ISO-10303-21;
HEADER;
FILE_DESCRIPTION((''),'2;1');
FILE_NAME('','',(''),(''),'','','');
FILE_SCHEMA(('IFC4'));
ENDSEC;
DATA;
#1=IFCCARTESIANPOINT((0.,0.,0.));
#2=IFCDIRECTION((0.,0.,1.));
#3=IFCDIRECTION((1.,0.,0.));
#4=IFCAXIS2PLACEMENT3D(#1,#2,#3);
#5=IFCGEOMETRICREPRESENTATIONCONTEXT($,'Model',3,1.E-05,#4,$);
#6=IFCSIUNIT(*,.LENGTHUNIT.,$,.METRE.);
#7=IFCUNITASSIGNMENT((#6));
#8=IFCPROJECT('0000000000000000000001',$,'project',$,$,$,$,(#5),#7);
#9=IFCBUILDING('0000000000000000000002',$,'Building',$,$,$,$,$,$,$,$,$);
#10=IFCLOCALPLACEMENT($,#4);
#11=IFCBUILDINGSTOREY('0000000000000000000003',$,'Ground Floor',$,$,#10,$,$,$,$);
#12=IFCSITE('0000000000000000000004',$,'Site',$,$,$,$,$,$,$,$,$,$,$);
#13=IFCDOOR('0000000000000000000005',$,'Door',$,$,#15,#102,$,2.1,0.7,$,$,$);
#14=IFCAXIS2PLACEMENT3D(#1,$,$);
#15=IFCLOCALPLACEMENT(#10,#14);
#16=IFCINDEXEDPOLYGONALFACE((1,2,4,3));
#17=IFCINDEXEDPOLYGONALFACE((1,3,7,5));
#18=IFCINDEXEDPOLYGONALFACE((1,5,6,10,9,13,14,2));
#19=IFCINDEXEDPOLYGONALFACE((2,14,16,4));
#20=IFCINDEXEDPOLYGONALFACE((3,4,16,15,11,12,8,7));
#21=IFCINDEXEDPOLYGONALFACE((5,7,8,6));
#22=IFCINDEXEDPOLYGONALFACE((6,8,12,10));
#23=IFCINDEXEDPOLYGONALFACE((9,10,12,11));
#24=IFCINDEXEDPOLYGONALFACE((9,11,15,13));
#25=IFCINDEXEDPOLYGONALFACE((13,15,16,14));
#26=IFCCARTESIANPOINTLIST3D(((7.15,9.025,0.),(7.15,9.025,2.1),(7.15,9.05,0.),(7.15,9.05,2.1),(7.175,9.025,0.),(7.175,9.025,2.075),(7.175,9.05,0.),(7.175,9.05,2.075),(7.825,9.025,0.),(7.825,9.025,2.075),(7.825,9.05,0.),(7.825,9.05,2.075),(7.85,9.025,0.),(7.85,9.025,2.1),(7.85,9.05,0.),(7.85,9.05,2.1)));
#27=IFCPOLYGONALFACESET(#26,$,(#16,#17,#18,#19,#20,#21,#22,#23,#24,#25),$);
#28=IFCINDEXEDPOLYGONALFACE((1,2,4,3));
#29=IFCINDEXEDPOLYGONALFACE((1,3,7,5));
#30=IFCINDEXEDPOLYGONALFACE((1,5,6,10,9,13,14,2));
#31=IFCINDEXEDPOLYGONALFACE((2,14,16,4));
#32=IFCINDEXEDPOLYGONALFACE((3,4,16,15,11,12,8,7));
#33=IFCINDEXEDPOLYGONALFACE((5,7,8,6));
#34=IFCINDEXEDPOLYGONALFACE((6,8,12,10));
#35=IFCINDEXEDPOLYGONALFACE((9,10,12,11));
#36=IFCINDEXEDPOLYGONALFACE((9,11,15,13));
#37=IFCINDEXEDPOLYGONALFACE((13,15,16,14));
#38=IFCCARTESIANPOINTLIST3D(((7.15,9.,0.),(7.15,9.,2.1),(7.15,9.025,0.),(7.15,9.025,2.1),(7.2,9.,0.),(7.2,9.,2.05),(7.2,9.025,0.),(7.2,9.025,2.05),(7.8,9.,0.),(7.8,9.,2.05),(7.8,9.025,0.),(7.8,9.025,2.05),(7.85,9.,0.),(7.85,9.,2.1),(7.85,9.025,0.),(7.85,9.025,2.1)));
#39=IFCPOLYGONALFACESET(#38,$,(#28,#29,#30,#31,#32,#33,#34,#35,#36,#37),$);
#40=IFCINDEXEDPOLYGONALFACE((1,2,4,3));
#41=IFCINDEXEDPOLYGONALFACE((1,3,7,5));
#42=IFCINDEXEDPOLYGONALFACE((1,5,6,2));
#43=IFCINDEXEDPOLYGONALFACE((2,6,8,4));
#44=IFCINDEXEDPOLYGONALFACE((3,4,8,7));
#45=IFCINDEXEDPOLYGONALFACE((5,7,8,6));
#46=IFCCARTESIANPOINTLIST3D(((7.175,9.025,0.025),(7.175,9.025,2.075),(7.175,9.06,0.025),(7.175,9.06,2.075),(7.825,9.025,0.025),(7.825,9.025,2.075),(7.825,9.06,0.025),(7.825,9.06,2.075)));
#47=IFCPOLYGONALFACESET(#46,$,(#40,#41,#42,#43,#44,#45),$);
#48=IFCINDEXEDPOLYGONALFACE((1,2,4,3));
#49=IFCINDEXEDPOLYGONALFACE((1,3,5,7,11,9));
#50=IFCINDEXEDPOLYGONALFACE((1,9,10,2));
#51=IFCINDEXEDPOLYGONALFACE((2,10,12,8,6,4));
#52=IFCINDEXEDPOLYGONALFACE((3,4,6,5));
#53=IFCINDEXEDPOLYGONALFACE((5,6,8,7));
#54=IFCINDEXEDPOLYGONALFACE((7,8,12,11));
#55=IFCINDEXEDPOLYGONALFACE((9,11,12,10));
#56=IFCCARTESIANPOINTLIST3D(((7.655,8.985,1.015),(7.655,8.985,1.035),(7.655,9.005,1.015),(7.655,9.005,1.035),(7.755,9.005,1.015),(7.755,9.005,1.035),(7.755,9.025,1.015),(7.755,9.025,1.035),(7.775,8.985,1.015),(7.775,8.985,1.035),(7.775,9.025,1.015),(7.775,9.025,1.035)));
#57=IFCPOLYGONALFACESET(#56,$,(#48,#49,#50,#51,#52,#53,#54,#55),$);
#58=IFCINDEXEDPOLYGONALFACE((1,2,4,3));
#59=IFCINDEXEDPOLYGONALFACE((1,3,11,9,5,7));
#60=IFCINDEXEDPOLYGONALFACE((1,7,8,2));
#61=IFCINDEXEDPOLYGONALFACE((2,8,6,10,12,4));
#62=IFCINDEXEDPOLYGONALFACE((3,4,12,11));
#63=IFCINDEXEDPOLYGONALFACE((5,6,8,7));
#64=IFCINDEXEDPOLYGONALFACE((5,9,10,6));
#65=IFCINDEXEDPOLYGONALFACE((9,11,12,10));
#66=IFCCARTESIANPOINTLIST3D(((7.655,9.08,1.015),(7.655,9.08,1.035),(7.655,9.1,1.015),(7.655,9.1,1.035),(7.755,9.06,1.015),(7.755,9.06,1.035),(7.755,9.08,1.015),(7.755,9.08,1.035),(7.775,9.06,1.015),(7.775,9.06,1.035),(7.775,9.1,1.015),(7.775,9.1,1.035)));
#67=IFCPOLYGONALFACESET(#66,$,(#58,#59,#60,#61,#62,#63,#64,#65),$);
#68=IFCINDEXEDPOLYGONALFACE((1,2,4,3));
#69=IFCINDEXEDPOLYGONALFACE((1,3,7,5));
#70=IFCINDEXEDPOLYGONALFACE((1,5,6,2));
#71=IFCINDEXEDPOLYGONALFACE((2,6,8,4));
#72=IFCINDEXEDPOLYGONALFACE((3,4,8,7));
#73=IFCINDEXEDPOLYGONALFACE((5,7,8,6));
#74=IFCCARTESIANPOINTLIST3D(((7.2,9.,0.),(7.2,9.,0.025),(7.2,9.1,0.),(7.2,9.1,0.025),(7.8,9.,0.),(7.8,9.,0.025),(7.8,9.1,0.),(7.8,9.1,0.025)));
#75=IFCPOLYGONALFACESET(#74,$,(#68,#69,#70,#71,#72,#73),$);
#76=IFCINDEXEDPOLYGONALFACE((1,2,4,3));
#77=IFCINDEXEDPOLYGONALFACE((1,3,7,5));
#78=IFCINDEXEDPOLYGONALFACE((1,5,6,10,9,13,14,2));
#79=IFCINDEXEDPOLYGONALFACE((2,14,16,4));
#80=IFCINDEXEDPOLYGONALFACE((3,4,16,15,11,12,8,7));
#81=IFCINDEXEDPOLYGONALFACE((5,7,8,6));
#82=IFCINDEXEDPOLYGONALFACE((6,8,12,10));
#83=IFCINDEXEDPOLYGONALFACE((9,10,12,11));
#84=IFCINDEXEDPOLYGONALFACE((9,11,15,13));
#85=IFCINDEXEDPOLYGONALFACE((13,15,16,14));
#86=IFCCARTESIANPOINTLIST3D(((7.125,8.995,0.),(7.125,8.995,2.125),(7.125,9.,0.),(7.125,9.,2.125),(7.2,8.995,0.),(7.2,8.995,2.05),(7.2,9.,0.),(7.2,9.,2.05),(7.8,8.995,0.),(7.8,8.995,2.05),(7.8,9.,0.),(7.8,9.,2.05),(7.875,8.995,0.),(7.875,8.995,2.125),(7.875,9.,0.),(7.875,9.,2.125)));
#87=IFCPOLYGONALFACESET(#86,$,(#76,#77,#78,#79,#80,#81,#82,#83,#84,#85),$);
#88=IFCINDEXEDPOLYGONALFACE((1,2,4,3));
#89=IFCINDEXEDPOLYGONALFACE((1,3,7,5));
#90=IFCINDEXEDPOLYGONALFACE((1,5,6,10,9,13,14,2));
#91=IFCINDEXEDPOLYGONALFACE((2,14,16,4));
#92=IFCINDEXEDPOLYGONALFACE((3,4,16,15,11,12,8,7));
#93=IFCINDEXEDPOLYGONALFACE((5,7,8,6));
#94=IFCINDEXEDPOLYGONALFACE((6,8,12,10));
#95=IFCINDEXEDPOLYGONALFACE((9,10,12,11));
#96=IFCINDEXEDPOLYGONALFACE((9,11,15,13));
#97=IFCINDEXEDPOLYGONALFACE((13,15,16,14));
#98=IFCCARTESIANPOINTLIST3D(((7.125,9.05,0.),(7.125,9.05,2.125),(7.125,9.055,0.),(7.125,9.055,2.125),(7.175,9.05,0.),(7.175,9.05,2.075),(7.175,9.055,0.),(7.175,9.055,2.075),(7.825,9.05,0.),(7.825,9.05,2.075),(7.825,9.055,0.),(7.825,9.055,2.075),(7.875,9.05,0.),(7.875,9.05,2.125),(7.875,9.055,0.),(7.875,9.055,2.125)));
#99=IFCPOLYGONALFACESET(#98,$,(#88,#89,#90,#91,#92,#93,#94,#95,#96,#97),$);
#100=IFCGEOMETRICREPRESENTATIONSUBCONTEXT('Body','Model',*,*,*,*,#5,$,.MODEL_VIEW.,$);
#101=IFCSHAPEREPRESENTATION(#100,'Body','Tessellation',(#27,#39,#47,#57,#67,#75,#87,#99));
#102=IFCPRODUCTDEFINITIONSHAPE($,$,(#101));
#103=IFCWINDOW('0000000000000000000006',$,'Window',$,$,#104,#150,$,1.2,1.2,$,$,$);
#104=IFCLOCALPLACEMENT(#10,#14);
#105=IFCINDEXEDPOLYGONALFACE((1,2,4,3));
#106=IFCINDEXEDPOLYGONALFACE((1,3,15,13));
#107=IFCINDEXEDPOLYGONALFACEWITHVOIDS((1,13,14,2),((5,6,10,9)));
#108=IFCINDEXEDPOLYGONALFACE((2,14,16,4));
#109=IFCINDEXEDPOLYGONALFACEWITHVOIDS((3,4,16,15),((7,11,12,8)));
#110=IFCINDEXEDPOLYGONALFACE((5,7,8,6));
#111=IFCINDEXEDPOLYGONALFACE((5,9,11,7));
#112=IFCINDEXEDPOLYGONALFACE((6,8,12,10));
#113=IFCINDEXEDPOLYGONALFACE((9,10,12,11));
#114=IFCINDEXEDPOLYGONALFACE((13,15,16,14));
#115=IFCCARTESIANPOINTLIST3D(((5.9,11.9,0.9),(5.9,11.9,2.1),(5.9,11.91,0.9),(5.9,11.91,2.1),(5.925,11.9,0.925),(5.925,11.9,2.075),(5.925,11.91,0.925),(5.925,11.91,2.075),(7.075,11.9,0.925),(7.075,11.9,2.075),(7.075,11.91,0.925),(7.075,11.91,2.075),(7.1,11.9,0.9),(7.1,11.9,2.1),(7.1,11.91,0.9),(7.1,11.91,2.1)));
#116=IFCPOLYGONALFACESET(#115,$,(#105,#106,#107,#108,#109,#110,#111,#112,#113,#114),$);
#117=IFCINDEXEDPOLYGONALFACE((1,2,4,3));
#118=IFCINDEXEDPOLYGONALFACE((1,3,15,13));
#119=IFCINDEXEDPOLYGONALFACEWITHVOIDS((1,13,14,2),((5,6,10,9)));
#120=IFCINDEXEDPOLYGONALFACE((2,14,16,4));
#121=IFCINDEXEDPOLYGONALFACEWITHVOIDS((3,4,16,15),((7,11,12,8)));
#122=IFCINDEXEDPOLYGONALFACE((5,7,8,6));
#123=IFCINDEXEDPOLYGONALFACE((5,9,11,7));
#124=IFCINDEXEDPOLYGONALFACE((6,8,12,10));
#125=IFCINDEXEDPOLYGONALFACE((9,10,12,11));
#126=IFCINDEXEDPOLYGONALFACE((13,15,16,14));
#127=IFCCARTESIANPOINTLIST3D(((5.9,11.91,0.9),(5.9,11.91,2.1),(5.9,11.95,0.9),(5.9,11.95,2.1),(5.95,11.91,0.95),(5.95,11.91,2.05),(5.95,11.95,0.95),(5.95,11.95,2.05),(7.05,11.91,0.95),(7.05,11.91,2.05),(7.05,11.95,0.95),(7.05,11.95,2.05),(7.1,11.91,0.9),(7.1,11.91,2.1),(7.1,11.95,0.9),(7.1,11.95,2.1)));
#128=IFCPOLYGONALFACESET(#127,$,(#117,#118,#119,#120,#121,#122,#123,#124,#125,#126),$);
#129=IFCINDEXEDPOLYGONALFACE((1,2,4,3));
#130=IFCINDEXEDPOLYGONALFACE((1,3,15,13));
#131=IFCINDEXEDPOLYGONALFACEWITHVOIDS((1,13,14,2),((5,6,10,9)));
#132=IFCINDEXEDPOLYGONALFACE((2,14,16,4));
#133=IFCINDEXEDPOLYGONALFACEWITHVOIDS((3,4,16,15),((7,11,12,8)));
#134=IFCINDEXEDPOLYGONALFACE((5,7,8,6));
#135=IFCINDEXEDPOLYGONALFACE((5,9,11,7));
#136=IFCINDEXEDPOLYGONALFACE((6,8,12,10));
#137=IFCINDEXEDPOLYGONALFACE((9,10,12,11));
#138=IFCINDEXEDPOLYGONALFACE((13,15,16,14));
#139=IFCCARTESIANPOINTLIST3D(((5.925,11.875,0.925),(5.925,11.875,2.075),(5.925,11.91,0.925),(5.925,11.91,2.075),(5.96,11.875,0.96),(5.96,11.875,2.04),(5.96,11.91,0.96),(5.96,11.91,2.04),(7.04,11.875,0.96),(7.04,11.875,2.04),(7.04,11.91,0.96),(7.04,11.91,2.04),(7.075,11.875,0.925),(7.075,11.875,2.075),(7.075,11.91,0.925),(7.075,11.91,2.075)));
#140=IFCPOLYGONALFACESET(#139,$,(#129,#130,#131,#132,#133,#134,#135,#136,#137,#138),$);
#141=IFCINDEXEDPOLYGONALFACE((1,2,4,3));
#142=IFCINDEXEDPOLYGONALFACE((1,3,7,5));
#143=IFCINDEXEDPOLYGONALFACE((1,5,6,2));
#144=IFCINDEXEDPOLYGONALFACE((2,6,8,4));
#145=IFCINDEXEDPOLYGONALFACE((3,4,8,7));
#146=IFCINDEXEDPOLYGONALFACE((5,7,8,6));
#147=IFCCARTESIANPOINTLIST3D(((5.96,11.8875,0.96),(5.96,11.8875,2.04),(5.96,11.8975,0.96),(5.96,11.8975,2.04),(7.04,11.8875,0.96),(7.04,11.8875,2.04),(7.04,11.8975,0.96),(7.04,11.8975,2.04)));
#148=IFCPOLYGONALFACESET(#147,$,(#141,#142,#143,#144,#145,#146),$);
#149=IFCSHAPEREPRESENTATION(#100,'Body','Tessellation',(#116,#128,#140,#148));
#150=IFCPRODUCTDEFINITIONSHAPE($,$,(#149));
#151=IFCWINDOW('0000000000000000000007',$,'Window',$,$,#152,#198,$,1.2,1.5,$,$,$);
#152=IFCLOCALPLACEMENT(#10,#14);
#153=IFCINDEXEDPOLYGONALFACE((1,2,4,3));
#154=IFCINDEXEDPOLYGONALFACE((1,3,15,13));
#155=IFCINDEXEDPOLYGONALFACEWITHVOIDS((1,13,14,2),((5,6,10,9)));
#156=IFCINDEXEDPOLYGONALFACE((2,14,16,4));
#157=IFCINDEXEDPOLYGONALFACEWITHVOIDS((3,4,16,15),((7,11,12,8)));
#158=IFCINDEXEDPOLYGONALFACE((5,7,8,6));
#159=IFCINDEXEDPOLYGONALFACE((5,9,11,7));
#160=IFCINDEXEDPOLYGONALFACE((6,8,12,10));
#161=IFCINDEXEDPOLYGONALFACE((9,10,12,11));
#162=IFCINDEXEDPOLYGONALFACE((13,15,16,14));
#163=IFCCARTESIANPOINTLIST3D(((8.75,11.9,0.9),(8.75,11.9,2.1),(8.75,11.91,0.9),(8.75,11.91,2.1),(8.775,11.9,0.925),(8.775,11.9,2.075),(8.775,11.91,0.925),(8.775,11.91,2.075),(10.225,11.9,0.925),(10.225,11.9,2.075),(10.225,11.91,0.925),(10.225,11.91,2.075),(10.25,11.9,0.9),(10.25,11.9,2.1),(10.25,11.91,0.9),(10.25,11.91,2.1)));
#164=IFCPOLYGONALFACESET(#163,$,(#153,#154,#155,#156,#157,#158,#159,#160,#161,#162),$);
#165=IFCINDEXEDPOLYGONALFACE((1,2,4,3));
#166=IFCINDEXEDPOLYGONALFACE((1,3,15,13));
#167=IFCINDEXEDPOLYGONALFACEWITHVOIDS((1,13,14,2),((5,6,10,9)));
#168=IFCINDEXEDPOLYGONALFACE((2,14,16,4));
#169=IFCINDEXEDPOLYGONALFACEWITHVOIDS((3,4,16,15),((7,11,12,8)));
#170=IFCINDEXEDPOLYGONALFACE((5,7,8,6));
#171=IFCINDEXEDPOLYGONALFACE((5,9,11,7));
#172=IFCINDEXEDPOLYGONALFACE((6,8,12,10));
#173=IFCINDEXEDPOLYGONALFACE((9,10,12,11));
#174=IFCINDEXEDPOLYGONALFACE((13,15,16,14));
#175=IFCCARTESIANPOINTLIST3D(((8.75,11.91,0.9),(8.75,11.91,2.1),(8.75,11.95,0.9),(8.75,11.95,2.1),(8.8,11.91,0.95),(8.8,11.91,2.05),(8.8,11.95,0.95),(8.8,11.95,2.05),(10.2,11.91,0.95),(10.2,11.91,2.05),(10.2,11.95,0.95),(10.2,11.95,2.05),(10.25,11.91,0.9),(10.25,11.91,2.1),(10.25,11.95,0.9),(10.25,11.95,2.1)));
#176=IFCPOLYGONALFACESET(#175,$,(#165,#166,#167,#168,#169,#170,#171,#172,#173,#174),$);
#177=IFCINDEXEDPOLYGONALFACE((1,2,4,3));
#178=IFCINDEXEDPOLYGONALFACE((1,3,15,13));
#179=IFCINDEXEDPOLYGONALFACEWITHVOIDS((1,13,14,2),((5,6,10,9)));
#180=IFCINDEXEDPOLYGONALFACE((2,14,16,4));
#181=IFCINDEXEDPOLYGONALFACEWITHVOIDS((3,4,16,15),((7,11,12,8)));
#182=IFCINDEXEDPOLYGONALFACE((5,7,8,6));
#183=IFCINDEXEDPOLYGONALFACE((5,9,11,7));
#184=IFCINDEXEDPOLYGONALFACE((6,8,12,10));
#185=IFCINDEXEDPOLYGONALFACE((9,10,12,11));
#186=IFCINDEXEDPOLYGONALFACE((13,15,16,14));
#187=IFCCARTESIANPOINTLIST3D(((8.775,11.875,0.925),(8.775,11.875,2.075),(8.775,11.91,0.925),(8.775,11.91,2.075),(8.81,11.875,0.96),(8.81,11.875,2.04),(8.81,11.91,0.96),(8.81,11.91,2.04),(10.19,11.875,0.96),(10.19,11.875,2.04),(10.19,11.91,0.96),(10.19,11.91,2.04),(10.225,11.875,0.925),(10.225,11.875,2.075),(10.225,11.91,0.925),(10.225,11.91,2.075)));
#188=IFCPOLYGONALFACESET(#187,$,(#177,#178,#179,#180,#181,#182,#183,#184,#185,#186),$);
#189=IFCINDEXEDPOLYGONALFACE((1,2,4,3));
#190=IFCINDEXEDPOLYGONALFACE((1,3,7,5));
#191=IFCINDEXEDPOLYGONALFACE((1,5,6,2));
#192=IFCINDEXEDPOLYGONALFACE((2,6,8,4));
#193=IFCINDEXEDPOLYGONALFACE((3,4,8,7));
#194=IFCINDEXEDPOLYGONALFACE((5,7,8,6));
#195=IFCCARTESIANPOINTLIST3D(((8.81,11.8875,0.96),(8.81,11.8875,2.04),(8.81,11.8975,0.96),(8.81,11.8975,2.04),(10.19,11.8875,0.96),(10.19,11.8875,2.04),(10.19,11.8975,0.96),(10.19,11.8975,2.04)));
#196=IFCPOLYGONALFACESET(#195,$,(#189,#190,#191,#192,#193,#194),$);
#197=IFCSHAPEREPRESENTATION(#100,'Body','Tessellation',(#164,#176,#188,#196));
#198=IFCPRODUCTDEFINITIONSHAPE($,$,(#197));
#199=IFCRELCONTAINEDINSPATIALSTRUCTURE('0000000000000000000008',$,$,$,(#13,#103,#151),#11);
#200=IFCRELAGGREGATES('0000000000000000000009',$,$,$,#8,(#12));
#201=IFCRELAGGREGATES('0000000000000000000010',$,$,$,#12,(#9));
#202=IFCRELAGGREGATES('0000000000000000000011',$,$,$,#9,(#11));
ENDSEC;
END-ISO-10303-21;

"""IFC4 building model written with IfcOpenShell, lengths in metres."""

from ifc_helpers import new_model, si_unit, frame, origin_with_axes, place, context, subcontext, project, spatial, line, indexed_curve, outline, extrude, element, save


model = new_model("IFC4")

# Units and contexts
model_context = context("Model", 3, precision=1e-05, world=origin_with_axes())
body_context = subcontext(model_context, "Body", "Model", "MODEL_VIEW")
ifc_project = project(units=[si_unit("LENGTHUNIT", "METRE")], contexts=[model_context])

# Site, building, storey
site = spatial("IfcSite", under=ifc_project, Name="Site")
building = spatial("IfcBuilding", under=site, Name="Building")
storey_placement = place(None, origin_with_axes())
storey = spatial("IfcBuildingStorey", under=building, at=storey_placement, Name="Ground Floor")

# Door
door_1_placement = place(storey_placement, frame((7.15, 9.0, 0.0), z_axis=(0.0, 0.0, 1.0), x_axis=(1.0, 0.0, 0.0)))
element("IfcDoor", 1, at=door_1_placement, inside=storey, Name="Door", OverallHeight=2.1, OverallWidth=0.7, context=body_context, shape_type="SweptSolid", body=[
    extrude(outline(indexed_curve([(0.0, 0.0), (0.0, 2.1), (0.7, 2.1), (0.7, 0.0), (0.675, 0.0), (0.675, 2.075), (0.025, 2.075), (0.025, 0.0)], segments=[line(1, 2, 3, 4, 5, 6, 7, 8, 1)])), frame((0.0, 0.025, 0.0), z_axis=(0.0, -1.0, 0.0), x_axis=(1.0, 0.0, 0.0)), (0.0, 0.0, -1.0), 0.025),
    extrude(outline(indexed_curve([(0.0, 0.0), (0.0, 2.1), (0.7, 2.1), (0.7, 0.0), (0.65, 0.0), (0.65, 2.05), (0.05, 2.05), (0.05, 0.0)], segments=[line(1, 2, 3, 4, 5, 6, 7, 8, 1)])), frame((0.0, 0.0, 0.0), z_axis=(0.0, -1.0, 0.0), x_axis=(1.0, 0.0, 0.0)), (0.0, 0.0, -1.0), 0.025),
    extrude(outline(indexed_curve([(0.0, 0.0), (0.65, 0.0), (0.65, 0.035), (0.0, 0.035)], segments=[line(1, 2, 3, 4, 1)])), frame((0.025, 0.025, 0.025), z_axis=(0.0, 0.0, 1.0), x_axis=(1.0, 0.0, 0.0)), (0.0, 0.0, 1.0), 2.05),
    extrude(outline(indexed_curve([(0.0, 0.0), (0.0, -0.04), (-0.12, -0.04), (-0.12, -0.02), (-0.02, -0.02), (-0.02, 0.0)], segments=[line(1, 2, 3, 4, 5, 6, 1)])), frame((0.625, 0.025, 1.015), z_axis=(0.0, 0.0, 1.0), x_axis=(1.0, 0.0, 0.0)), (0.0, 0.0, 1.0), 0.02),
    extrude(outline(indexed_curve([(0.0, 0.0), (0.0, 0.04), (-0.12, 0.04), (-0.12, 0.02), (-0.02, 0.02), (-0.02, 0.0)], segments=[line(1, 2, 3, 4, 5, 6, 1)])), frame((0.625, 0.06, 1.015), z_axis=(0.0, 0.0, 1.0), x_axis=(1.0, 0.0, 0.0)), (0.0, 0.0, 1.0), 0.02),
    extrude(outline(indexed_curve([(0.0, 0.0), (0.6, 0.0), (0.6, 0.1), (0.0, 0.1)], segments=[line(1, 2, 3, 4, 1)])), frame((0.05, 0.0, 0.0), z_axis=(0.0, 0.0, 1.0), x_axis=(1.0, 0.0, 0.0)), (0.0, 0.0, 1.0), 0.025),
    extrude(outline(indexed_curve([(0.0, 0.0), (0.0, 2.125), (0.75, 2.125), (0.75, 0.0), (0.675, 0.0), (0.675, 2.05), (0.075, 2.05), (0.075, 0.0)], segments=[line(1, 2, 3, 4, 5, 6, 7, 8, 1)])), frame((-0.025, -0.005, 0.0), z_axis=(0.0, -1.0, 0.0), x_axis=(1.0, 0.0, 0.0)), (0.0, 0.0, -1.0), 0.005),
    extrude(outline(indexed_curve([(0.0, 0.0), (0.0, 2.125), (0.75, 2.125), (0.75, 0.0), (0.7, 0.0), (0.7, 2.075), (0.05, 2.075), (0.05, 0.0)], segments=[line(1, 2, 3, 4, 5, 6, 7, 8, 1)])), frame((-0.025, 0.05, 0.0), z_axis=(0.0, -1.0, 0.0), x_axis=(1.0, 0.0, 0.0)), (0.0, 0.0, -1.0), 0.005),
])

# Windows
window_placement = place(storey_placement, frame((7.1, 12.0, 0.9), z_axis=(0.0, 0.0, 1.0), x_axis=(-1.0, 0.0, 0.0)))
element("IfcWindow", 2, at=window_placement, inside=storey, Name="Window", OverallHeight=1.2, OverallWidth=1.2, context=body_context, shape_type="SweptSolid", body=[
    extrude(outline(indexed_curve([(0.0, 0.0), (1.2, 0.0), (1.2, 1.2), (0.0, 1.2)], segments=[line(1, 2, 3, 4, 1)]), holes=[indexed_curve([(0.025, 0.025), (1.175, 0.025), (1.175, 1.175), (0.025, 1.175)], segments=[line(1, 2, 3, 4, 1)])]), frame((0.0, 0.09, 0.0), z_axis=(0.0, -1.0, 0.0), x_axis=(1.0, 0.0, 0.0)), (0.0, 0.0, -1.0), 0.01),
    extrude(outline(indexed_curve([(0.0, 0.0), (1.2, 0.0), (1.2, 1.2), (0.0, 1.2)], segments=[line(1, 2, 3, 4, 1)]), holes=[indexed_curve([(0.05, 0.05), (1.15, 0.05), (1.15, 1.15), (0.05, 1.15)], segments=[line(1, 2, 3, 4, 1)])]), frame((0.0, 0.05, 0.0), z_axis=(0.0, -1.0, 0.0), x_axis=(1.0, 0.0, 0.0)), (0.0, 0.0, -1.0), 0.04),
    extrude(outline(indexed_curve([(0.0, 0.0), (1.15, 0.0), (1.15, 1.15), (0.0, 1.15)], segments=[line(1, 2, 3, 4, 1)]), holes=[indexed_curve([(0.035, 0.035), (1.115, 0.035), (1.115, 1.115), (0.035, 1.115)], segments=[line(1, 2, 3, 4, 1)])]), frame((0.025, 0.09, 0.025), z_axis=(0.0, -1.0, 0.0), x_axis=(1.0, 0.0, 0.0)), (0.0, 0.0, -1.0), 0.035),
    extrude(outline(indexed_curve([(0.035, 0.035), (1.115, 0.035), (1.115, 1.115), (0.035, 1.115)], segments=[line(1, 2, 3, 4, 1)])), frame((0.025, 0.1025, 0.025), z_axis=(0.0, -1.0, 0.0), x_axis=(1.0, 0.0, 0.0)), (0.0, 0.0, -1.0), 0.01),
])
for number, where, z_axis, x_axis, name in (
    (3, (10.25, 12.0, 0.9), (0.0, 0.0, 1.0), (-1.0, 0.0, 0.0), "Window"),
):
    element("IfcWindow", number, at=place(storey_placement, frame(where, z_axis=z_axis, x_axis=x_axis)), inside=storey, Name=name, OverallHeight=1.2, OverallWidth=1.5, context=body_context, shape_type="SweptSolid", body=[
        extrude(outline(indexed_curve([(0.0, 0.0), (1.5, 0.0), (1.5, 1.2), (0.0, 1.2)], segments=[line(1, 2, 3, 4, 1)]), holes=[indexed_curve([(0.025, 0.025), (1.475, 0.025), (1.475, 1.175), (0.025, 1.175)], segments=[line(1, 2, 3, 4, 1)])]), frame((0.0, 0.09, 0.0), z_axis=(0.0, -1.0, 0.0), x_axis=(1.0, 0.0, 0.0)), (0.0, 0.0, -1.0), 0.01),
        extrude(outline(indexed_curve([(0.0, 0.0), (1.5, 0.0), (1.5, 1.2), (0.0, 1.2)], segments=[line(1, 2, 3, 4, 1)]), holes=[indexed_curve([(0.05, 0.05), (1.45, 0.05), (1.45, 1.15), (0.05, 1.15)], segments=[line(1, 2, 3, 4, 1)])]), frame((0.0, 0.05, 0.0), z_axis=(0.0, -1.0, 0.0), x_axis=(1.0, 0.0, 0.0)), (0.0, 0.0, -1.0), 0.04),
        extrude(outline(indexed_curve([(0.0, 0.0), (1.45, 0.0), (1.45, 1.15), (0.0, 1.15)], segments=[line(1, 2, 3, 4, 1)]), holes=[indexed_curve([(0.035, 0.035), (1.415, 0.035), (1.415, 1.115), (0.035, 1.115)], segments=[line(1, 2, 3, 4, 1)])]), frame((0.025, 0.09, 0.025), z_axis=(0.0, -1.0, 0.0), x_axis=(1.0, 0.0, 0.0)), (0.0, 0.0, -1.0), 0.035),
        extrude(outline(indexed_curve([(0.035, 0.035), (1.415, 0.035), (1.415, 1.115), (0.035, 1.115)], segments=[line(1, 2, 3, 4, 1)])), frame((0.025, 0.1025, 0.025), z_axis=(0.0, -1.0, 0.0), x_axis=(1.0, 0.0, 0.0)), (0.0, 0.0, -1.0), 0.01),
    ])

save(model, "model.ifc")
